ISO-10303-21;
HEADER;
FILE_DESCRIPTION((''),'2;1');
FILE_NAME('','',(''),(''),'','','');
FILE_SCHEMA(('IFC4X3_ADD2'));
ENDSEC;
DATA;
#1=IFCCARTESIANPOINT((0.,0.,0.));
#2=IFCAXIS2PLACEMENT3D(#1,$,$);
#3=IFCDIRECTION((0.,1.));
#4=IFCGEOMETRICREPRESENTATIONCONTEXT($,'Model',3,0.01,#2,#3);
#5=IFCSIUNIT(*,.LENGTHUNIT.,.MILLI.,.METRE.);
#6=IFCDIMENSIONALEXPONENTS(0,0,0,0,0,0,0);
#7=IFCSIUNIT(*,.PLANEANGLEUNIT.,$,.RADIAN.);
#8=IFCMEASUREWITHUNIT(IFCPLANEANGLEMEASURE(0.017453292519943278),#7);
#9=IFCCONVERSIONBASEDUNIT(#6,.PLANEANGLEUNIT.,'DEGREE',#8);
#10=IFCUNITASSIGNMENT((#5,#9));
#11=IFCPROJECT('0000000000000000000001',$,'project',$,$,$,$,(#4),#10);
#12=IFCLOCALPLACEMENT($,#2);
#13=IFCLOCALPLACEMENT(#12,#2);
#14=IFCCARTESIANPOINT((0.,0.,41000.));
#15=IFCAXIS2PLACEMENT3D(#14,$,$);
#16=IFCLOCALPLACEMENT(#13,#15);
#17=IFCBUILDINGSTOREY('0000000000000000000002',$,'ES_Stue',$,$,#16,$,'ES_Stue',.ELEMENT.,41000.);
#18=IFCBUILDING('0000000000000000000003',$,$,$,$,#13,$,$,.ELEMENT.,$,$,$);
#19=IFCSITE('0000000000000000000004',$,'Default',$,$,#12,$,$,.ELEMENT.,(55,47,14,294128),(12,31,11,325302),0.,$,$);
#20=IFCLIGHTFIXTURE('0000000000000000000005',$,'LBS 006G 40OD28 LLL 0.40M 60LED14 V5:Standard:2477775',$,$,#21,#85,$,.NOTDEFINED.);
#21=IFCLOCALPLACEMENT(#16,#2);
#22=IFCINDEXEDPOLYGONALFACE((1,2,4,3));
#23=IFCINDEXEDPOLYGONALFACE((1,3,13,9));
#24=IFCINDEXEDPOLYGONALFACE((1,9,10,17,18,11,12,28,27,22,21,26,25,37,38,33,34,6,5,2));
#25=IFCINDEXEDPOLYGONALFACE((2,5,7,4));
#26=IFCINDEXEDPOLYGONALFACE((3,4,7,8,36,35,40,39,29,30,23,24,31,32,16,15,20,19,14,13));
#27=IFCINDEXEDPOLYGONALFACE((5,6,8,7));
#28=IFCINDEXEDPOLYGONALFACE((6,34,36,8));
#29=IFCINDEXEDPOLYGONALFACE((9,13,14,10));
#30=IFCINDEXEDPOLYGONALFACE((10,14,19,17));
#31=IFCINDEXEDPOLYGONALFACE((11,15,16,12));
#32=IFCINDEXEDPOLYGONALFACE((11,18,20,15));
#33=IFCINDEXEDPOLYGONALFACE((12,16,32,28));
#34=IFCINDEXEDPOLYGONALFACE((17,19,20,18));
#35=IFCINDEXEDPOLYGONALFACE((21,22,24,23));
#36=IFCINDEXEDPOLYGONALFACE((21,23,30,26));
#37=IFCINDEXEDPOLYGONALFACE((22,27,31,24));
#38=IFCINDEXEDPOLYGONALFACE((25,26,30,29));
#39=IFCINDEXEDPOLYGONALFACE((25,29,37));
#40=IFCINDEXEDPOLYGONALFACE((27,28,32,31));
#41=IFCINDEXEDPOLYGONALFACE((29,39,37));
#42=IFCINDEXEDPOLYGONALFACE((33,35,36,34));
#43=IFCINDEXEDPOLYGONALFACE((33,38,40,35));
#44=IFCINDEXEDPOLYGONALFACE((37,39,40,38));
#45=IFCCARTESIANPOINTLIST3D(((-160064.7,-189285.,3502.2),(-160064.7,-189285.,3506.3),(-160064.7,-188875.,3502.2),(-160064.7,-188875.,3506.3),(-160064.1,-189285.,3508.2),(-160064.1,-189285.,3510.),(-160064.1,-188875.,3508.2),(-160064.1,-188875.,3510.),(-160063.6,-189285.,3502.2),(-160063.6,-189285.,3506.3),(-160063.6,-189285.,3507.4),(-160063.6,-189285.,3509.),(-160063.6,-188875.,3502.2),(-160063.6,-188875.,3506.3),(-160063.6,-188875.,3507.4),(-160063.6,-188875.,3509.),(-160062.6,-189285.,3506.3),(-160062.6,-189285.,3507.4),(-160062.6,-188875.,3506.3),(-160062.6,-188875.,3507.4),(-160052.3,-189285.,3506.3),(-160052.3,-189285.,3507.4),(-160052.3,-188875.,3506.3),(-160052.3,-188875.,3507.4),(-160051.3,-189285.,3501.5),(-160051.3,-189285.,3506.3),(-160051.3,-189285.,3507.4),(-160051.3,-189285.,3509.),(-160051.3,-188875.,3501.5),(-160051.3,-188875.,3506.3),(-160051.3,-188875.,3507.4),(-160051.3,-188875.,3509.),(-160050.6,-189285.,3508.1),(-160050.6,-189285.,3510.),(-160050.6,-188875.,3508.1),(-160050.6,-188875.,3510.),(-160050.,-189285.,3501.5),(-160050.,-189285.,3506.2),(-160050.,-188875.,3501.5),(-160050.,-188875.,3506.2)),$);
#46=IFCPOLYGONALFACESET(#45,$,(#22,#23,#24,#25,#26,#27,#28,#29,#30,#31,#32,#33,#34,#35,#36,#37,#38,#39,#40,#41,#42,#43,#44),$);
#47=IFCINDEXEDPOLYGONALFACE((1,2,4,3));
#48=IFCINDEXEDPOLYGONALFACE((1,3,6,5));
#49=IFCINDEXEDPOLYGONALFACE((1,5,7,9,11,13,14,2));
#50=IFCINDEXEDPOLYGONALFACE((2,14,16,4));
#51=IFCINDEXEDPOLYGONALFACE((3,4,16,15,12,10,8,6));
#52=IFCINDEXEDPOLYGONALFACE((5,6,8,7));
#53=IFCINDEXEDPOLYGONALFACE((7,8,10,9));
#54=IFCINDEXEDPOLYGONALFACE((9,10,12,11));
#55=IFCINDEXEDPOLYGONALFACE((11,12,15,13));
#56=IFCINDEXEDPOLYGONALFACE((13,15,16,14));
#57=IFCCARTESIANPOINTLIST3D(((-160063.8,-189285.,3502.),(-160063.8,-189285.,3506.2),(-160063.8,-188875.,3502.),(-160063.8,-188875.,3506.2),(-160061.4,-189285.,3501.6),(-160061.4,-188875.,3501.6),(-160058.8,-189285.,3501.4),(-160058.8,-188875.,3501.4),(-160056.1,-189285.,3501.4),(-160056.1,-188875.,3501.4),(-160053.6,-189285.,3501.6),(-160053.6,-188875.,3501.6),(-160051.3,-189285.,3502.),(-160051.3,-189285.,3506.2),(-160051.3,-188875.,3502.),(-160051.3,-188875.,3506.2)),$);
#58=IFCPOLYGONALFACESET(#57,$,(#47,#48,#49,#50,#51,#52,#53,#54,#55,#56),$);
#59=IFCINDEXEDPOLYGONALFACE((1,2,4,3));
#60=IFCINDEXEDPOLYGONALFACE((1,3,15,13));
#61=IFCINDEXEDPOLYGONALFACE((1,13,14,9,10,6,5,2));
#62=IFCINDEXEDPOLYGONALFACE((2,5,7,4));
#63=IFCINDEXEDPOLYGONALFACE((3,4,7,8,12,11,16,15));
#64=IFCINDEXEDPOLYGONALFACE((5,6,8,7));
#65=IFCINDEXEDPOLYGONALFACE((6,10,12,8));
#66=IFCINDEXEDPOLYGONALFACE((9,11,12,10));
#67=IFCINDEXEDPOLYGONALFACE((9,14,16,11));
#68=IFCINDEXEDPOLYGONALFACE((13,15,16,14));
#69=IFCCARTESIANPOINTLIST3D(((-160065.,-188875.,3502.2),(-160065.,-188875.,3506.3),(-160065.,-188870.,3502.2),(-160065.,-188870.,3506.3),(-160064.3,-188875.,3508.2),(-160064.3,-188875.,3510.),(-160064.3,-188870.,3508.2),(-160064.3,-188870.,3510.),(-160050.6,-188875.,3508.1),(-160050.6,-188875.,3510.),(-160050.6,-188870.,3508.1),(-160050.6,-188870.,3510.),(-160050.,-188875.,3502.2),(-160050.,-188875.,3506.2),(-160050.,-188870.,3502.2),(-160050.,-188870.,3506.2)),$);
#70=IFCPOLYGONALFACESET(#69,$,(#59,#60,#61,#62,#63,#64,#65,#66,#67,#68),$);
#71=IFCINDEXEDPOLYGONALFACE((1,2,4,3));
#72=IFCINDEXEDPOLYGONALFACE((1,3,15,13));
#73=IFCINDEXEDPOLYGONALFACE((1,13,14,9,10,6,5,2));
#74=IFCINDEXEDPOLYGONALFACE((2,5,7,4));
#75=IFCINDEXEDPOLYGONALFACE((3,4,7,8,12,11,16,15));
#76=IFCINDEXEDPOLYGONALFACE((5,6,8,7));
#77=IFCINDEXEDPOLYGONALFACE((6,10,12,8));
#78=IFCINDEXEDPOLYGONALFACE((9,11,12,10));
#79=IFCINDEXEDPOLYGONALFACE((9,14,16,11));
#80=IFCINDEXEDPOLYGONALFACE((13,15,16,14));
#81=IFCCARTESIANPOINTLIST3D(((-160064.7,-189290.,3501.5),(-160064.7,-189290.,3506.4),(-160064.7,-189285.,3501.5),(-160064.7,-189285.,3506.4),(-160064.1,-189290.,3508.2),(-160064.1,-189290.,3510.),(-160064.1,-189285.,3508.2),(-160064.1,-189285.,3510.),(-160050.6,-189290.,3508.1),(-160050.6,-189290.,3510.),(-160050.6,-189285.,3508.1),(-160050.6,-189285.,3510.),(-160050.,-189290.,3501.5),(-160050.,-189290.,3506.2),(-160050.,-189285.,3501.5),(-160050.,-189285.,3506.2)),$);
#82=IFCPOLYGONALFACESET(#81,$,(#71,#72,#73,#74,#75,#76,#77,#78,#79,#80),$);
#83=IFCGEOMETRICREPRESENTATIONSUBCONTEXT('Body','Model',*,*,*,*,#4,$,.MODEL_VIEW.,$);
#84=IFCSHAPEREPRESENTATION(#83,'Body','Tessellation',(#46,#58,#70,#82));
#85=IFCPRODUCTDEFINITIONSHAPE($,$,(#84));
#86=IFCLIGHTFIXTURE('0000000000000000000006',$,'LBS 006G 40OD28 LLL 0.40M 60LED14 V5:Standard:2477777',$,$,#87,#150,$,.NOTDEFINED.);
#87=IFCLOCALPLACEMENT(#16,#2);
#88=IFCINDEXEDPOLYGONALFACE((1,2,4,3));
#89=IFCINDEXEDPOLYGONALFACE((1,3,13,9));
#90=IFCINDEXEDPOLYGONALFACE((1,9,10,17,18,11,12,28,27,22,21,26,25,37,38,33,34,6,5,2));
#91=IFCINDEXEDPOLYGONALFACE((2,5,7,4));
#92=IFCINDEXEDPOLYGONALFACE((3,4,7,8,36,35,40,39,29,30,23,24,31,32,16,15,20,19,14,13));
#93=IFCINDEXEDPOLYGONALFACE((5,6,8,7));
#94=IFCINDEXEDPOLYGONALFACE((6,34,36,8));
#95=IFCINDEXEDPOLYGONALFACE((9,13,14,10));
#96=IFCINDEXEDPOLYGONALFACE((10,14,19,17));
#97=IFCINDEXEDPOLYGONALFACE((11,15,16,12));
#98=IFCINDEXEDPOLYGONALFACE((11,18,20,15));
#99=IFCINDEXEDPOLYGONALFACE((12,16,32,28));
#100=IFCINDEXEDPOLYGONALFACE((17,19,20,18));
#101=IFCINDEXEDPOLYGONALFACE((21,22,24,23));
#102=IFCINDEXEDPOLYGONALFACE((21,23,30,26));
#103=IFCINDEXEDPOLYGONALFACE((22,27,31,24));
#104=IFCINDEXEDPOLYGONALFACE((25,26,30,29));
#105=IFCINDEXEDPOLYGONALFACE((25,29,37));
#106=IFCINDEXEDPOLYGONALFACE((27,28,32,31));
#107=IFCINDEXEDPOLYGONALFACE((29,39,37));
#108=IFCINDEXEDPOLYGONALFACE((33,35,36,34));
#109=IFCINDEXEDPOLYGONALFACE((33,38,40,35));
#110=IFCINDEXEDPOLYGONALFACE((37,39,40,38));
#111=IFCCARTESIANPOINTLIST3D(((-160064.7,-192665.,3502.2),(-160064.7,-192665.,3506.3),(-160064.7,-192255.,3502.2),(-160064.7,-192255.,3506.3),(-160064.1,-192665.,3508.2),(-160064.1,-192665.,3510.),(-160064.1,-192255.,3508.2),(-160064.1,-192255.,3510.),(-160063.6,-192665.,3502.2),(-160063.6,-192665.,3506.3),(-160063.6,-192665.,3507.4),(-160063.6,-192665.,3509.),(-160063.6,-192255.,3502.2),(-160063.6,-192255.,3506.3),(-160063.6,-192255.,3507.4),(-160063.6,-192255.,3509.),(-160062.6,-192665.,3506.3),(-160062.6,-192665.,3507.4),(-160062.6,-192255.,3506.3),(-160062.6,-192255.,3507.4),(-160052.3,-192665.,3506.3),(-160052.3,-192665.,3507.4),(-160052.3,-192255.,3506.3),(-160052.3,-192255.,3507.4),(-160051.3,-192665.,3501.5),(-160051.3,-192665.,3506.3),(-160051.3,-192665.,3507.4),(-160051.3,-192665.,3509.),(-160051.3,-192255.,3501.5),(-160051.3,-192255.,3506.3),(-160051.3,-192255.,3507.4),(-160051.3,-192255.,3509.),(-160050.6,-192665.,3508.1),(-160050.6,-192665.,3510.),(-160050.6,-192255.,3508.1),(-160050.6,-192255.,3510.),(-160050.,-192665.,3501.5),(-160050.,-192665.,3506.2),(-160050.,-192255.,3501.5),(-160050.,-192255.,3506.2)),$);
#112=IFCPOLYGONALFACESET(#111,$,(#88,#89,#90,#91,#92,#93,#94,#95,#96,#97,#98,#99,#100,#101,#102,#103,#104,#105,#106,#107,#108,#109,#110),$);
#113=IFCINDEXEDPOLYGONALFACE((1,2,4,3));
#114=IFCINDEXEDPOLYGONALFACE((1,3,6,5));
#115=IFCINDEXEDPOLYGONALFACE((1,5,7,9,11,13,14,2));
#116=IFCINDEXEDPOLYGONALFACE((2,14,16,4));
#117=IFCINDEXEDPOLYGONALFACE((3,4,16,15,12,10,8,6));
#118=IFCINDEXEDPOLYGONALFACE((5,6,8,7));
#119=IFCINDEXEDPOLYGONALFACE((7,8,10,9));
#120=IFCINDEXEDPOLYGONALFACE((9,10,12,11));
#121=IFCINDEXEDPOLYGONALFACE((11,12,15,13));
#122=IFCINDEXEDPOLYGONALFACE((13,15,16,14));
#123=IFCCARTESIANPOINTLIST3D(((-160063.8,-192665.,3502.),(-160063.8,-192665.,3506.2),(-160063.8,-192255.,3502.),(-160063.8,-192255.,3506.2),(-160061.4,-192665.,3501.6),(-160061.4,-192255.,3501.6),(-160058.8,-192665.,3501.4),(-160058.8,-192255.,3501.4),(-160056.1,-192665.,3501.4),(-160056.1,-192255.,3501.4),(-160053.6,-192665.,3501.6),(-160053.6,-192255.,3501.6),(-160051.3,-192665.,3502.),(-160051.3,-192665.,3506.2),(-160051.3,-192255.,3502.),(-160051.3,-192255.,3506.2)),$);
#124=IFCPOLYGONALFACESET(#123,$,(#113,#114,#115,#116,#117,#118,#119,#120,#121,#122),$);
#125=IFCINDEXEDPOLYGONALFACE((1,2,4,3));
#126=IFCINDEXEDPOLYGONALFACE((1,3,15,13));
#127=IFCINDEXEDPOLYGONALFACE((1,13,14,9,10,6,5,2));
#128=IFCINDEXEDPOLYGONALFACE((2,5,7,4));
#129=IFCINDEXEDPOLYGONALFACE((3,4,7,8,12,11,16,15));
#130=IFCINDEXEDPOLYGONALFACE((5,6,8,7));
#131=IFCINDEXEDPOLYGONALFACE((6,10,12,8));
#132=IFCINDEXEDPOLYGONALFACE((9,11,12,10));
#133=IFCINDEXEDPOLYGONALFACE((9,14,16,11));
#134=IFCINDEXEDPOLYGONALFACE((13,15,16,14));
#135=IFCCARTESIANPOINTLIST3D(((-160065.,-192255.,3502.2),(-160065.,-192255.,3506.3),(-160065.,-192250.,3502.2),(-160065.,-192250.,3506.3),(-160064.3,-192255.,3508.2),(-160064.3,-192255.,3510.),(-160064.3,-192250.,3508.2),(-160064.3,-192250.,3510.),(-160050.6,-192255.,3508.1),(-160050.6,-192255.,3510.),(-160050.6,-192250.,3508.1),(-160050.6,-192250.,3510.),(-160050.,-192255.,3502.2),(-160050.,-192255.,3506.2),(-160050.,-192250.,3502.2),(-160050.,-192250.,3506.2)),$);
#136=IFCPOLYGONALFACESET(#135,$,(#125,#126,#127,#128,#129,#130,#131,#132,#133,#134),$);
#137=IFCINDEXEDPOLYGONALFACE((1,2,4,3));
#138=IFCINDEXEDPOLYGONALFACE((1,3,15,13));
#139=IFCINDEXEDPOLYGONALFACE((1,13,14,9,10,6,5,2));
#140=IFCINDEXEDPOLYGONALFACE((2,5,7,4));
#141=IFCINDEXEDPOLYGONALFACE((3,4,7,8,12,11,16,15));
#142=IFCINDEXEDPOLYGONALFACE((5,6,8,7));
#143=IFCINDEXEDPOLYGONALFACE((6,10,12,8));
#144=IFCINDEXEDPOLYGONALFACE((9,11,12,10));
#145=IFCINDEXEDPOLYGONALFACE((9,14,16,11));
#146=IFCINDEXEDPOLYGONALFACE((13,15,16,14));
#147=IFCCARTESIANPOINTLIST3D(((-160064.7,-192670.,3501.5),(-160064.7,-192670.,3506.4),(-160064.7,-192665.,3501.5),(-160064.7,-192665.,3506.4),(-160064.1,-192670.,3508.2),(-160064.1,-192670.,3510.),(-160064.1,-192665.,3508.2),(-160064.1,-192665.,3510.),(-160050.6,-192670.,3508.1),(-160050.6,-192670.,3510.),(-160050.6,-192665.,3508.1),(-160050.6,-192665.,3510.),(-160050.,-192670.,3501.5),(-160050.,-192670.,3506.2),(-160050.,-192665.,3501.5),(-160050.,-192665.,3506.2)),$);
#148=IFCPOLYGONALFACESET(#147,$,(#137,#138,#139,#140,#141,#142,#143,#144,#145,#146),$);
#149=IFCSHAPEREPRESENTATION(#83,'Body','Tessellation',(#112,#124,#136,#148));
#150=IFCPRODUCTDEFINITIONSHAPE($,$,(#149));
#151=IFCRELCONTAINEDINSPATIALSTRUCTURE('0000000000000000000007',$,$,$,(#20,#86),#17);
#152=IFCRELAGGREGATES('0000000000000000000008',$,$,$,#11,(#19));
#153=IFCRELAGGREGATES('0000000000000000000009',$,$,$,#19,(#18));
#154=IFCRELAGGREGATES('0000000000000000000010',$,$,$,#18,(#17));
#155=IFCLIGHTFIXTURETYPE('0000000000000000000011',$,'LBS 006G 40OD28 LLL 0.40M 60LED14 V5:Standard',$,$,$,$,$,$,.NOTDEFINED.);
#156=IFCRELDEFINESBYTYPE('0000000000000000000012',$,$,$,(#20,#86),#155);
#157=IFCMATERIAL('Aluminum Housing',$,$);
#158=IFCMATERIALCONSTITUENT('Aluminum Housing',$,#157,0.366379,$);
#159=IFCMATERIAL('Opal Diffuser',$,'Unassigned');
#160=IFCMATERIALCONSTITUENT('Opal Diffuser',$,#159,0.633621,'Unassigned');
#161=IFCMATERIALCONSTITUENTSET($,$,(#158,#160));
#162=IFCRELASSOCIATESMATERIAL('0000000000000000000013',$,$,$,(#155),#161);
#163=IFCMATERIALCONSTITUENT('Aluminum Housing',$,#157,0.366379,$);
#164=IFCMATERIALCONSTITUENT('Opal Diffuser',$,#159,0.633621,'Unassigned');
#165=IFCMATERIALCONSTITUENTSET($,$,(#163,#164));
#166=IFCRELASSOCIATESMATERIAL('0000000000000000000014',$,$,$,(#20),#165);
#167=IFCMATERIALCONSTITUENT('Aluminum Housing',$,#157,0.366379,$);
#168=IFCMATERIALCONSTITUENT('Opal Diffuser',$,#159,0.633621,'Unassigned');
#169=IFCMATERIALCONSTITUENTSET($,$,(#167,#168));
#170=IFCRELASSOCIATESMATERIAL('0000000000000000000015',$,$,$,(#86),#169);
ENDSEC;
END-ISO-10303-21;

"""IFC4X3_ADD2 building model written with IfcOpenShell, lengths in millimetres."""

from ifc_helpers import new_model, entity, si_unit, converted_unit, direction, frame, origin, place, context, subcontext, project, spatial, polyline, outline, extrude, source, transform, mapped, material, constituent, constituent_set, type_object, type_shapes, element, save


model = new_model("IFC4X3_ADD2")

# Units and contexts
model_context = context("Model", 3, precision=0.01, world=origin(), true_north=direction((0.0, 1.0)))
body_context = subcontext(model_context, "Body", "Model", "MODEL_VIEW")
ifc_project = project(units=[si_unit("LENGTHUNIT", "METRE", prefix="MILLI"), converted_unit("PLANEANGLEUNIT", "DEGREE", entity("IfcPlaneAngleMeasure", 0.017453292519943278), si_unit("PLANEANGLEUNIT", "RADIAN"), dimensions=[0, 0, 0, 0, 0, 0, 0])], contexts=[model_context])

# Site, building, storey
site_placement = place(None, origin())
site = spatial("IfcSite", under=ifc_project, at=site_placement, Name="Default", CompositionType="ELEMENT", RefLatitude=(55, 47, 14, 294128), RefLongitude=(12, 31, 11, 325302), RefElevation=0.0)
building_placement = place(site_placement, origin())
building = spatial("IfcBuilding", under=site, at=building_placement, CompositionType="ELEMENT")
storey_placement = place(building_placement, frame((0.0, 0.0, 41000.0)))
storey = spatial("IfcBuildingStorey", under=building, at=storey_placement, Name="ES_Stue", LongName="ES_Stue", CompositionType="ELEMENT", Elevation=41000.0)

# Light fixtures
ifc_material_1 = material(Name="Aluminum Housing")
ifc_constituent_1 = constituent(ifc_material_1, Name="Aluminum Housing", fraction=0.366379)
ifc_material_2 = material(Name="Opal Diffuser", Category="Unassigned")
ifc_constituent_2 = constituent(ifc_material_2, Name="Opal Diffuser", Category="Unassigned", fraction=0.633621)
ifc_constituent_set_1 = constituent_set(constituents=[ifc_constituent_1, ifc_constituent_2])
ifc_constituent_3 = constituent(ifc_material_1, Name="Aluminum Housing", fraction=0.366379)
ifc_constituent_4 = constituent(ifc_material_2, Name="Opal Diffuser", Category="Unassigned", fraction=0.633621)
ifc_constituent_set_2 = constituent_set(constituents=[ifc_constituent_3, ifc_constituent_4])
light_fixture_type = type_object("IfcLightFixtureType", Name="LBS 006G 40OD28 LLL 0.40M 60LED14 V5:Standard", PredefinedType="NOTDEFINED", material=ifc_constituent_set_2)
shared_shape_1 = source(origin(), body_context, "Body", "SweptSolid", [
    extrude(outline(polyline([(-5.0, -6.1), (-5.0, -7.4), (-0.3, -7.4), (1.7, -6.8), (3.5, -6.8), (3.5, 6.7), (1.8, 6.7), (-0.1, 7.3), (-4.2, 7.3), (-4.2, 6.2), (-0.1, 6.2), (-0.1, 5.2), (0.9, 5.2), (0.9, 6.2), (2.5, 6.2), (2.5, -6.1), (0.9, -6.1), (0.9, -5.1), (-0.1, -5.1), (-0.1, -6.1), (-5.0, -6.1)])), frame((-205.0, 0.1, 3.5), z_axis=(-1.0, 0.0, 0.0), x_axis=(0.0, 0.0, -1.0)), (0.0, 0.0, -1.0), 410.0),
    extrude(outline(polyline([(-0.8, -6.2), (3.4, -6.2), (3.4, 6.2), (-0.8, 6.2), (-1.2, 3.9), (-1.4, 1.4), (-1.4, -1.3), (-1.2, -3.9), (-0.8, -6.2)])), frame((-205.0, 0.0, 7.2), z_axis=(1.0, 0.0, 0.0), x_axis=(0.0, 0.0, -1.0)), (0.0, 0.0, 1.0), 410.0),
    extrude(outline(polyline([(-4.4, -7.5), (-0.3, -7.5), (1.5, -6.8), (3.3, -6.8), (3.3, 6.9), (1.5, 6.9), (-0.5, 7.4), (-4.4, 7.4), (-4.4, -7.5)])), frame((205.0, 0.0, 3.3), z_axis=(1.0, 0.0, 0.0), x_axis=(0.0, 0.0, -1.0)), (0.0, 0.0, 1.0), 5.0),
    extrude(outline(polyline([(-5.0, -7.4), (-0.1, -7.4), (1.7, -6.7), (3.5, -6.7), (3.5, 6.8), (1.6, 6.8), (-0.3, 7.3), (-5.0, 7.3), (-5.0, -7.4)])), frame((-210.0, 0.2, 3.5), z_axis=(1.0, 0.0, 0.0), x_axis=(0.0, 0.0, -1.0)), (0.0, 0.0, 1.0), 5.0),
])
type_shapes(light_fixture_type, [shared_shape_1])
light_fixture_1_placement = place(storey_placement, frame((-160057.5, -189080.0, 3510.0), z_axis=(0.0, 0.0, -1.0), x_axis=(0.0, 1.0, 0.0)))
element("IfcLightFixture", 1, at=light_fixture_1_placement, inside=storey, type_object=light_fixture_type, material=ifc_constituent_set_1, Name="LBS 006G 40OD28 LLL 0.40M 60LED14 V5:Standard:2477775", PredefinedType="NOTDEFINED", context=body_context, shape_type="MappedRepresentation", body=[
    mapped(shared_shape_1, transform((0.0, 0.0, 0.0), scale=1.0)),
])
ifc_constituent_5 = constituent(ifc_material_1, Name="Aluminum Housing", fraction=0.366379)
ifc_constituent_6 = constituent(ifc_material_2, Name="Opal Diffuser", Category="Unassigned", fraction=0.633621)
ifc_constituent_set_3 = constituent_set(constituents=[ifc_constituent_5, ifc_constituent_6])
light_fixture_2_placement = place(storey_placement, frame((-160057.5, -192460.0, 3510.0), z_axis=(0.0, 0.0, -1.0), x_axis=(0.0, 1.0, 0.0)))
element("IfcLightFixture", 2, at=light_fixture_2_placement, inside=storey, type_object=light_fixture_type, material=ifc_constituent_set_3, Name="LBS 006G 40OD28 LLL 0.40M 60LED14 V5:Standard:2477777", PredefinedType="NOTDEFINED", context=body_context, shape_type="MappedRepresentation", body=[
    mapped(shared_shape_1, transform((0.0, 0.0, 0.0), scale=1.0)),
])

save(model, "model.ifc")
